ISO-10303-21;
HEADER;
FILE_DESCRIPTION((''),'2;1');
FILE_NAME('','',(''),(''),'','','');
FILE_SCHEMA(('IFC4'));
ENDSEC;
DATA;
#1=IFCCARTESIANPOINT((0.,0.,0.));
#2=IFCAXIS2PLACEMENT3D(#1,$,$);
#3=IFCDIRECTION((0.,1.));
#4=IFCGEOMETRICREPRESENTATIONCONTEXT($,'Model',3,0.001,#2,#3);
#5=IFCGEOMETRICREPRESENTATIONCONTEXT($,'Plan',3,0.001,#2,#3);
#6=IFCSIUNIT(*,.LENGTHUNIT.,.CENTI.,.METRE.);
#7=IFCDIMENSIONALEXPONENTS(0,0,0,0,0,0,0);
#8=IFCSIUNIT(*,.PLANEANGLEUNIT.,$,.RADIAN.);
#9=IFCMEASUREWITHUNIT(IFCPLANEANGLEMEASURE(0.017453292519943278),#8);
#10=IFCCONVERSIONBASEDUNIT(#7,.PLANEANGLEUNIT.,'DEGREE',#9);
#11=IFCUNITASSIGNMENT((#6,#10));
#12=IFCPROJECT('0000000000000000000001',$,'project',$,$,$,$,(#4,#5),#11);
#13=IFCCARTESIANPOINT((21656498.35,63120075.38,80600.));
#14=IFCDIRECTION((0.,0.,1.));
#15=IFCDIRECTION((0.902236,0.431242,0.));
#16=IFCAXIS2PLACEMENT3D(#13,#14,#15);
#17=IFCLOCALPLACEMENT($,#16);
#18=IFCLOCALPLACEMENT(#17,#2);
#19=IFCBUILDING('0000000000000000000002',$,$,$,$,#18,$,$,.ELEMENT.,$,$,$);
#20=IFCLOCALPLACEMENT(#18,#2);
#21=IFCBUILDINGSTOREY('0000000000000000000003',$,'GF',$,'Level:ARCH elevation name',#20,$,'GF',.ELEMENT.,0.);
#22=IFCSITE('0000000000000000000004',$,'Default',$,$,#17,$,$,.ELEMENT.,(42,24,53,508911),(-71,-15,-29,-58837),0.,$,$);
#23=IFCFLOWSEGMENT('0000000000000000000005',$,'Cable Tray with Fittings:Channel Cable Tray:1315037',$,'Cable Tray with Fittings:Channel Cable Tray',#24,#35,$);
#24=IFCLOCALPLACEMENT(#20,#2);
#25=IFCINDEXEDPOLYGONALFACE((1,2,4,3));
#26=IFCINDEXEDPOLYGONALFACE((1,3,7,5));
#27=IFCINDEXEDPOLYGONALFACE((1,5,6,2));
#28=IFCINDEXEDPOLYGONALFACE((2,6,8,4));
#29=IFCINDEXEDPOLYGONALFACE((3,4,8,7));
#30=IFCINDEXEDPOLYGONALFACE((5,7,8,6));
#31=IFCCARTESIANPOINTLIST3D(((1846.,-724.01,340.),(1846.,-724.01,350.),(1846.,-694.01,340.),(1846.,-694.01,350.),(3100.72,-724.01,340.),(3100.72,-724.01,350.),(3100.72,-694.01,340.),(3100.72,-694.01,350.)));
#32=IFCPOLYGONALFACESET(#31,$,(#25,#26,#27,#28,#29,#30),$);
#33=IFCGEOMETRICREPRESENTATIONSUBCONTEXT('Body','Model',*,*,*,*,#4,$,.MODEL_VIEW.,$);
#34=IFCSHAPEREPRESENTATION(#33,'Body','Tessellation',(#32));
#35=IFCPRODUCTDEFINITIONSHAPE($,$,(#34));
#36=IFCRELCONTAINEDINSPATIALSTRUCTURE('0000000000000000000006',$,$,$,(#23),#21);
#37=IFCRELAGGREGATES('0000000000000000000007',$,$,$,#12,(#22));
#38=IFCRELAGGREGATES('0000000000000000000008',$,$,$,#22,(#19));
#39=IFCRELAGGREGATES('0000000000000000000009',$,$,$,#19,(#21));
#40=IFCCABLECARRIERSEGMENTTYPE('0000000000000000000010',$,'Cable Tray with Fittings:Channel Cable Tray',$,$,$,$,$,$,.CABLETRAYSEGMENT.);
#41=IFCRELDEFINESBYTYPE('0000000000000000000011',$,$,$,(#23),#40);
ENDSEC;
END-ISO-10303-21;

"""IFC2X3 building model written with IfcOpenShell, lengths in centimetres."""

from ifc_helpers import new_model, entity, si_unit, converted_unit, direction, frame, origin, origin_2d_with_axis, place, context, subcontext, project, spatial, rectangle, extrude, type_object, element, save


model = new_model("IFC2X3")

# Units and contexts
model_context = context("Model", 3, precision=0.001, world=origin(), true_north=direction((0.0, 1.0)))
plan_context = context("Plan", 3, precision=0.001, world=origin(), true_north=direction((0.0, 1.0)))
body_context = subcontext(model_context, "Body", "Model", "MODEL_VIEW")
ifc_project = project(units=[si_unit("LENGTHUNIT", "METRE", prefix="CENTI"), converted_unit("PLANEANGLEUNIT", "DEGREE", entity("IfcPlaneAngleMeasure", 0.017453292519943278), si_unit("PLANEANGLEUNIT", "RADIAN"), dimensions=[0, 0, 0, 0, 0, 0, 0])], contexts=[model_context, plan_context])

# Site, building, storey
site_placement = place(None, frame((21656498.35, 63120075.38, 80600.0), z_axis=(0.0, 0.0, 1.0), x_axis=(0.902236, 0.431242, 0.0)))
site = spatial("IfcSite", under=ifc_project, at=site_placement, Name="Default", CompositionType="ELEMENT", RefLatitude=(42, 24, 53, 508911), RefLongitude=(-71, -15, -29, -58837), RefElevation=0.0)
building_placement = place(site_placement, origin())
building = spatial("IfcBuilding", under=site, at=building_placement, CompositionType="ELEMENT")
storey_placement = place(building_placement, origin())
storey = spatial("IfcBuildingStorey", under=building, at=storey_placement, Name="GF", ObjectType="Level:ARCH elevation name", LongName="GF", CompositionType="ELEMENT", Elevation=0.0)

# Flow segment
cable_carrier_segment_type_1 = type_object("IfcCableCarrierSegmentType", Name="Cable Tray with Fittings:Channel Cable Tray", PredefinedType="CABLETRAYSEGMENT")
flow_segment_1_placement = place(storey_placement, origin())
element("IfcFlowSegment", 1, at=flow_segment_1_placement, inside=storey, type_object=cable_carrier_segment_type_1, Name="Cable Tray with Fittings:Channel Cable Tray:1315037", ObjectType="Cable Tray with Fittings:Channel Cable Tray", context=body_context, shape_type="SweptSolid", body=[
    extrude(rectangle(XDim=1254.72, YDim=30.0, at=origin_2d_with_axis()), frame((2473.36, -709.01, 340.0)), (0.0, 0.0, 1.0), 10.0),
])

save(model, "model.ifc")
